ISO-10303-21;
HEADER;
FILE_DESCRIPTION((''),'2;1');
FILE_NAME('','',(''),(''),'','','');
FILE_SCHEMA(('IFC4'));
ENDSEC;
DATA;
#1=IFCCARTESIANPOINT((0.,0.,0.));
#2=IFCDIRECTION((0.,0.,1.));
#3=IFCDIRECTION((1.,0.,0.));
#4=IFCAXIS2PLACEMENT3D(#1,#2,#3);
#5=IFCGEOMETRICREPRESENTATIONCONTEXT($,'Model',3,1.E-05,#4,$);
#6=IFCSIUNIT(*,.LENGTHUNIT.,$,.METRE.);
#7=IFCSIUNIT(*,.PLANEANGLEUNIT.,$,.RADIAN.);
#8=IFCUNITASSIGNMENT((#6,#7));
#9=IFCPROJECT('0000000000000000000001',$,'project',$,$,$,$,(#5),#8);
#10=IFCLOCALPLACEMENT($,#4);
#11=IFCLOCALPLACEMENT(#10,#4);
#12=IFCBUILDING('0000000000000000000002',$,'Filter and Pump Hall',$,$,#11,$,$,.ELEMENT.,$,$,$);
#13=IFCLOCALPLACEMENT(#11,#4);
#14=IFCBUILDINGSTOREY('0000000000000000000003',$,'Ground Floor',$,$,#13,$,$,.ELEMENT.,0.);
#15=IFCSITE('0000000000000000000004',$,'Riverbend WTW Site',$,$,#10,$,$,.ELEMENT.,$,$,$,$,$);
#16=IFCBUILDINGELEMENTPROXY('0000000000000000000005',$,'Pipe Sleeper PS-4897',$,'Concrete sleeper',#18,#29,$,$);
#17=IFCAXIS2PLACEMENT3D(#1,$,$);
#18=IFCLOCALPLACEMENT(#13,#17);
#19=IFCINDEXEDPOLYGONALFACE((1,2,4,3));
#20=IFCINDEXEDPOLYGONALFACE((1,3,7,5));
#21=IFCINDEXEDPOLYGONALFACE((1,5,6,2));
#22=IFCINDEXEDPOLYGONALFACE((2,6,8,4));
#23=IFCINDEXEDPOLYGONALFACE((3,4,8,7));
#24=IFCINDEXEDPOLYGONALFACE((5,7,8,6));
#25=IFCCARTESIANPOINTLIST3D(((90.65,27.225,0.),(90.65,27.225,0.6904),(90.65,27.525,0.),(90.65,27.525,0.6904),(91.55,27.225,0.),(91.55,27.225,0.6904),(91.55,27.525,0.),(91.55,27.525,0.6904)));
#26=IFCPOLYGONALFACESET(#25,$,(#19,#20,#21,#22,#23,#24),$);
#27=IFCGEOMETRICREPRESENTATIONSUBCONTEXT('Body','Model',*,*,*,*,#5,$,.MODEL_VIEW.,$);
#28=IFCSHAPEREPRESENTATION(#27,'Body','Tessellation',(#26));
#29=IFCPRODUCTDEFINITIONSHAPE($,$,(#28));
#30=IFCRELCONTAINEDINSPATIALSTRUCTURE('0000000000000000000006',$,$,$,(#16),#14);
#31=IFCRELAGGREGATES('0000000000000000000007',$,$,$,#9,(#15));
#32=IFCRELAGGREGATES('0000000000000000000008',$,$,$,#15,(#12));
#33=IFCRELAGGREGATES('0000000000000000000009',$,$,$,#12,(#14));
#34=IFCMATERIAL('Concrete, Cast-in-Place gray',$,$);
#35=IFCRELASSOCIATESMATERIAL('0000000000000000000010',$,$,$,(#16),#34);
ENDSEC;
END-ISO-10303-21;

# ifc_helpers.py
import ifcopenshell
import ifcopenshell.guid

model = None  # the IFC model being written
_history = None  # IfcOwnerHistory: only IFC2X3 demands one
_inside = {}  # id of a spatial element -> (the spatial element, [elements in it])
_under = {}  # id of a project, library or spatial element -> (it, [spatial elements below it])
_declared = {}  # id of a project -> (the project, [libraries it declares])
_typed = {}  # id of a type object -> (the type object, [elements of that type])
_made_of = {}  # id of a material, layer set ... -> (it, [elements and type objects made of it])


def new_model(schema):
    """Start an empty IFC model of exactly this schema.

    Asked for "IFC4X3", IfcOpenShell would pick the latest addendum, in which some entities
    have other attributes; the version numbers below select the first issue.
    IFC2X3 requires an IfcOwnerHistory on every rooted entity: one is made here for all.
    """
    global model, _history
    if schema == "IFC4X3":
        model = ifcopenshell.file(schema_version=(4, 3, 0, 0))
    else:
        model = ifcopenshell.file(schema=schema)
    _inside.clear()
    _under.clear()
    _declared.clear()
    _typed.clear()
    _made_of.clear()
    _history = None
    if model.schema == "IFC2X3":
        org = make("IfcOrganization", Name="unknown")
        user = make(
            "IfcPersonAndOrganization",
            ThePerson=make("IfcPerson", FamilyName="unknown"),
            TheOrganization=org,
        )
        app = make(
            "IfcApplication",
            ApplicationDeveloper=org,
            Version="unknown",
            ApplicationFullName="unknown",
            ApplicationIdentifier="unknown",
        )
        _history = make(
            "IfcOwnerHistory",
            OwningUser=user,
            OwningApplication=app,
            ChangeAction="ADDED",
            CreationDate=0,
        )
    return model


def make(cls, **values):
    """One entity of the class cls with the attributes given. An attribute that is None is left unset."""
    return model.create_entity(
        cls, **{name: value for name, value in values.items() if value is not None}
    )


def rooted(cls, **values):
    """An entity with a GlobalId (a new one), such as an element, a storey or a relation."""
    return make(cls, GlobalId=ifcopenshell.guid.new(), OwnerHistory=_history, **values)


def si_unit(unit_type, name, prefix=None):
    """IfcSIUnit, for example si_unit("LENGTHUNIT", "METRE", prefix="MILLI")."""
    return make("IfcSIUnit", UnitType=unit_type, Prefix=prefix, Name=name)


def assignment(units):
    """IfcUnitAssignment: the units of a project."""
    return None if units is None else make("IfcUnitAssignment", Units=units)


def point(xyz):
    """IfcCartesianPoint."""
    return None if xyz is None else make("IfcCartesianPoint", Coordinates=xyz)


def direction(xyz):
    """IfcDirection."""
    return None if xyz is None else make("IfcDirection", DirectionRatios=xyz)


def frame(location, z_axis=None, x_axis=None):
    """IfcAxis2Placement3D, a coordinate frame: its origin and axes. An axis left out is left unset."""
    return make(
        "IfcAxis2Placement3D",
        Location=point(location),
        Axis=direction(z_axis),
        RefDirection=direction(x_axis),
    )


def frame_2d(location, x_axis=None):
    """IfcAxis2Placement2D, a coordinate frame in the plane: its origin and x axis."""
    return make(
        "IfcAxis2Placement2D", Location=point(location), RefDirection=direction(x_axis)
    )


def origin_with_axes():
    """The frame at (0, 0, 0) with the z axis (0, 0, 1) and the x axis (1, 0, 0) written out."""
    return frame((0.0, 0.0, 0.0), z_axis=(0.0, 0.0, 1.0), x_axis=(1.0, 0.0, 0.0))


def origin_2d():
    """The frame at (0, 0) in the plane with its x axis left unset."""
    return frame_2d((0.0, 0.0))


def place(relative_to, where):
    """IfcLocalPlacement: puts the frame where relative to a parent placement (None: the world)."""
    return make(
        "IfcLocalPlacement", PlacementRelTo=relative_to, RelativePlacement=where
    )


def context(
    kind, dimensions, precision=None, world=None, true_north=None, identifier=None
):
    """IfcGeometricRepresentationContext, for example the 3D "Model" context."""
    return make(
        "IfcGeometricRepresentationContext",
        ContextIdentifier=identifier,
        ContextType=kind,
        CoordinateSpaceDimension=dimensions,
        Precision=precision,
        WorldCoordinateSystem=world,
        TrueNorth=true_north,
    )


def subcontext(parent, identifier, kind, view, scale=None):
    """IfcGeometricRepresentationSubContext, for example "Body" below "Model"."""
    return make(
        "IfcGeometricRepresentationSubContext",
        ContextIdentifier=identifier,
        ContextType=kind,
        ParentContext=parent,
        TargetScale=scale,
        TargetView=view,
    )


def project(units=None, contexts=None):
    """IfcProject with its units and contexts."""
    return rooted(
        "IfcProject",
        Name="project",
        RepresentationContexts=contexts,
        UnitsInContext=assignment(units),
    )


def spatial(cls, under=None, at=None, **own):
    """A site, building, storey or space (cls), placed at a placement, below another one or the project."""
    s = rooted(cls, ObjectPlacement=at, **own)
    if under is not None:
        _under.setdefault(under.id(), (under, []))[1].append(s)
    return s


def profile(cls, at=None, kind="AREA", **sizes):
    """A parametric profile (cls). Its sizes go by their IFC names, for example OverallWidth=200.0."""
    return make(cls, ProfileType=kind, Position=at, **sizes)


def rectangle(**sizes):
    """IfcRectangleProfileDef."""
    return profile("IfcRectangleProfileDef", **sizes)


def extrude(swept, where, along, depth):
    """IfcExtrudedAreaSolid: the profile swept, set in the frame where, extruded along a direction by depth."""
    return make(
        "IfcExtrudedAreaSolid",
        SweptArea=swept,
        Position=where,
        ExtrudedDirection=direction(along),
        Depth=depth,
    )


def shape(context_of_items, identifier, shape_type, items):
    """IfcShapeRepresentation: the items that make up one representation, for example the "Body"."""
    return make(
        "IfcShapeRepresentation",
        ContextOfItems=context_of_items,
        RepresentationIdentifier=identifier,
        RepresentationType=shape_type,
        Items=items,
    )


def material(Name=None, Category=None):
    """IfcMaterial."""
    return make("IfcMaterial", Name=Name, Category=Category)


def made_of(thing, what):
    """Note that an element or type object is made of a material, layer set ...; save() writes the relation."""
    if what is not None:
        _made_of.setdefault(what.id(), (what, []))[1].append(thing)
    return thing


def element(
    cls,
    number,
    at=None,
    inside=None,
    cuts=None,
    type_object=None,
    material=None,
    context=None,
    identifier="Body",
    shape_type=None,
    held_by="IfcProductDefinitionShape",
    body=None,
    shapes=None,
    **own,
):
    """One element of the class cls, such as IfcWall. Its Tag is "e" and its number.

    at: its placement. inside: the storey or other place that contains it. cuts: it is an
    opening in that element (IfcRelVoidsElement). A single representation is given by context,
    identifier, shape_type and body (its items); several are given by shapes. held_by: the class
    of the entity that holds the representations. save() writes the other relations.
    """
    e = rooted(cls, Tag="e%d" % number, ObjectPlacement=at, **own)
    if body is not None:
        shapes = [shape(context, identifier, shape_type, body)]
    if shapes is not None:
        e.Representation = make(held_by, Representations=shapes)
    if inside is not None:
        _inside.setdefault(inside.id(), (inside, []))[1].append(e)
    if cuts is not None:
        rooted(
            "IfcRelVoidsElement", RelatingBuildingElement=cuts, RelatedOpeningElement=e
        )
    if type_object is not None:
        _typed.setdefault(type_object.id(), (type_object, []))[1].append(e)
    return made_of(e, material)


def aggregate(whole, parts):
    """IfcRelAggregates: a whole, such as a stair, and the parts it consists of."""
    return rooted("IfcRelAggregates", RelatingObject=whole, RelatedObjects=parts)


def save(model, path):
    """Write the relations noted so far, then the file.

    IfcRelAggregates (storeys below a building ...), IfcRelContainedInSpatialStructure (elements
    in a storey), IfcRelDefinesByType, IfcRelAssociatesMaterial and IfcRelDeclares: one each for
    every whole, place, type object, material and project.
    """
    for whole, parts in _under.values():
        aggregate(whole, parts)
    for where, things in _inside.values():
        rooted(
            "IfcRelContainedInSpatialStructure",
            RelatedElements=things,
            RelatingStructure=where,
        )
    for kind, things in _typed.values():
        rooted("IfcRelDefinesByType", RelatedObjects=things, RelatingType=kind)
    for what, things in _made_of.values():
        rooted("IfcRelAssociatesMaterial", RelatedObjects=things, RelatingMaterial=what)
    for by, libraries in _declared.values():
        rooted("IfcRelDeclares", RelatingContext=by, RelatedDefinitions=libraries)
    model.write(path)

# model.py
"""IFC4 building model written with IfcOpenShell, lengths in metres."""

from ifc_helpers import new_model, si_unit, frame, origin_with_axes, origin_2d, place, context, subcontext, project, spatial, rectangle, extrude, material, element, save


model = new_model("IFC4")

# Units and contexts
model_context = context("Model", 3, precision=1e-05, world=origin_with_axes())
body_context = subcontext(model_context, "Body", "Model", "MODEL_VIEW")
ifc_project = project(units=[si_unit("LENGTHUNIT", "METRE"), si_unit("PLANEANGLEUNIT", "RADIAN")], contexts=[model_context])

# Site, building, storey
site_placement = place(None, origin_with_axes())
site = spatial("IfcSite", under=ifc_project, at=site_placement, Name="Riverbend WTW Site", CompositionType="ELEMENT")
building_placement = place(site_placement, origin_with_axes())
building = spatial("IfcBuilding", under=site, at=building_placement, Name="Filter and Pump Hall", CompositionType="ELEMENT")
storey_placement = place(building_placement, origin_with_axes())
storey = spatial("IfcBuildingStorey", under=building, at=storey_placement, Name="Ground Floor", CompositionType="ELEMENT", Elevation=0.0)

# Shared definitions
ifc_material_1 = material(Name="Concrete, Cast-in-Place gray")

# Building element proxy
for number, where, z_axis, x_axis, name in (
    (1, (91.1, 27.375, 0.3452), (0.0, 0.0, 1.0), (1.0, 0.0, 0.0), "Pipe Sleeper PS-4897"),
):
    element("IfcBuildingElementProxy", number, at=place(None, frame(where, z_axis=z_axis, x_axis=x_axis)), inside=storey, material=ifc_material_1, Name=name, ObjectType="Concrete sleeper", context=body_context, shape_type="SweptSolid", body=[
        extrude(rectangle(XDim=0.9, YDim=0.3, at=origin_2d()), frame((0.0, 0.0, -0.3452), z_axis=(0.0, 0.0, 1.0), x_axis=(1.0, 0.0, 0.0)), (0.0, 0.0, 1.0), 0.6905),
    ])

save(model, "model.ifc")
